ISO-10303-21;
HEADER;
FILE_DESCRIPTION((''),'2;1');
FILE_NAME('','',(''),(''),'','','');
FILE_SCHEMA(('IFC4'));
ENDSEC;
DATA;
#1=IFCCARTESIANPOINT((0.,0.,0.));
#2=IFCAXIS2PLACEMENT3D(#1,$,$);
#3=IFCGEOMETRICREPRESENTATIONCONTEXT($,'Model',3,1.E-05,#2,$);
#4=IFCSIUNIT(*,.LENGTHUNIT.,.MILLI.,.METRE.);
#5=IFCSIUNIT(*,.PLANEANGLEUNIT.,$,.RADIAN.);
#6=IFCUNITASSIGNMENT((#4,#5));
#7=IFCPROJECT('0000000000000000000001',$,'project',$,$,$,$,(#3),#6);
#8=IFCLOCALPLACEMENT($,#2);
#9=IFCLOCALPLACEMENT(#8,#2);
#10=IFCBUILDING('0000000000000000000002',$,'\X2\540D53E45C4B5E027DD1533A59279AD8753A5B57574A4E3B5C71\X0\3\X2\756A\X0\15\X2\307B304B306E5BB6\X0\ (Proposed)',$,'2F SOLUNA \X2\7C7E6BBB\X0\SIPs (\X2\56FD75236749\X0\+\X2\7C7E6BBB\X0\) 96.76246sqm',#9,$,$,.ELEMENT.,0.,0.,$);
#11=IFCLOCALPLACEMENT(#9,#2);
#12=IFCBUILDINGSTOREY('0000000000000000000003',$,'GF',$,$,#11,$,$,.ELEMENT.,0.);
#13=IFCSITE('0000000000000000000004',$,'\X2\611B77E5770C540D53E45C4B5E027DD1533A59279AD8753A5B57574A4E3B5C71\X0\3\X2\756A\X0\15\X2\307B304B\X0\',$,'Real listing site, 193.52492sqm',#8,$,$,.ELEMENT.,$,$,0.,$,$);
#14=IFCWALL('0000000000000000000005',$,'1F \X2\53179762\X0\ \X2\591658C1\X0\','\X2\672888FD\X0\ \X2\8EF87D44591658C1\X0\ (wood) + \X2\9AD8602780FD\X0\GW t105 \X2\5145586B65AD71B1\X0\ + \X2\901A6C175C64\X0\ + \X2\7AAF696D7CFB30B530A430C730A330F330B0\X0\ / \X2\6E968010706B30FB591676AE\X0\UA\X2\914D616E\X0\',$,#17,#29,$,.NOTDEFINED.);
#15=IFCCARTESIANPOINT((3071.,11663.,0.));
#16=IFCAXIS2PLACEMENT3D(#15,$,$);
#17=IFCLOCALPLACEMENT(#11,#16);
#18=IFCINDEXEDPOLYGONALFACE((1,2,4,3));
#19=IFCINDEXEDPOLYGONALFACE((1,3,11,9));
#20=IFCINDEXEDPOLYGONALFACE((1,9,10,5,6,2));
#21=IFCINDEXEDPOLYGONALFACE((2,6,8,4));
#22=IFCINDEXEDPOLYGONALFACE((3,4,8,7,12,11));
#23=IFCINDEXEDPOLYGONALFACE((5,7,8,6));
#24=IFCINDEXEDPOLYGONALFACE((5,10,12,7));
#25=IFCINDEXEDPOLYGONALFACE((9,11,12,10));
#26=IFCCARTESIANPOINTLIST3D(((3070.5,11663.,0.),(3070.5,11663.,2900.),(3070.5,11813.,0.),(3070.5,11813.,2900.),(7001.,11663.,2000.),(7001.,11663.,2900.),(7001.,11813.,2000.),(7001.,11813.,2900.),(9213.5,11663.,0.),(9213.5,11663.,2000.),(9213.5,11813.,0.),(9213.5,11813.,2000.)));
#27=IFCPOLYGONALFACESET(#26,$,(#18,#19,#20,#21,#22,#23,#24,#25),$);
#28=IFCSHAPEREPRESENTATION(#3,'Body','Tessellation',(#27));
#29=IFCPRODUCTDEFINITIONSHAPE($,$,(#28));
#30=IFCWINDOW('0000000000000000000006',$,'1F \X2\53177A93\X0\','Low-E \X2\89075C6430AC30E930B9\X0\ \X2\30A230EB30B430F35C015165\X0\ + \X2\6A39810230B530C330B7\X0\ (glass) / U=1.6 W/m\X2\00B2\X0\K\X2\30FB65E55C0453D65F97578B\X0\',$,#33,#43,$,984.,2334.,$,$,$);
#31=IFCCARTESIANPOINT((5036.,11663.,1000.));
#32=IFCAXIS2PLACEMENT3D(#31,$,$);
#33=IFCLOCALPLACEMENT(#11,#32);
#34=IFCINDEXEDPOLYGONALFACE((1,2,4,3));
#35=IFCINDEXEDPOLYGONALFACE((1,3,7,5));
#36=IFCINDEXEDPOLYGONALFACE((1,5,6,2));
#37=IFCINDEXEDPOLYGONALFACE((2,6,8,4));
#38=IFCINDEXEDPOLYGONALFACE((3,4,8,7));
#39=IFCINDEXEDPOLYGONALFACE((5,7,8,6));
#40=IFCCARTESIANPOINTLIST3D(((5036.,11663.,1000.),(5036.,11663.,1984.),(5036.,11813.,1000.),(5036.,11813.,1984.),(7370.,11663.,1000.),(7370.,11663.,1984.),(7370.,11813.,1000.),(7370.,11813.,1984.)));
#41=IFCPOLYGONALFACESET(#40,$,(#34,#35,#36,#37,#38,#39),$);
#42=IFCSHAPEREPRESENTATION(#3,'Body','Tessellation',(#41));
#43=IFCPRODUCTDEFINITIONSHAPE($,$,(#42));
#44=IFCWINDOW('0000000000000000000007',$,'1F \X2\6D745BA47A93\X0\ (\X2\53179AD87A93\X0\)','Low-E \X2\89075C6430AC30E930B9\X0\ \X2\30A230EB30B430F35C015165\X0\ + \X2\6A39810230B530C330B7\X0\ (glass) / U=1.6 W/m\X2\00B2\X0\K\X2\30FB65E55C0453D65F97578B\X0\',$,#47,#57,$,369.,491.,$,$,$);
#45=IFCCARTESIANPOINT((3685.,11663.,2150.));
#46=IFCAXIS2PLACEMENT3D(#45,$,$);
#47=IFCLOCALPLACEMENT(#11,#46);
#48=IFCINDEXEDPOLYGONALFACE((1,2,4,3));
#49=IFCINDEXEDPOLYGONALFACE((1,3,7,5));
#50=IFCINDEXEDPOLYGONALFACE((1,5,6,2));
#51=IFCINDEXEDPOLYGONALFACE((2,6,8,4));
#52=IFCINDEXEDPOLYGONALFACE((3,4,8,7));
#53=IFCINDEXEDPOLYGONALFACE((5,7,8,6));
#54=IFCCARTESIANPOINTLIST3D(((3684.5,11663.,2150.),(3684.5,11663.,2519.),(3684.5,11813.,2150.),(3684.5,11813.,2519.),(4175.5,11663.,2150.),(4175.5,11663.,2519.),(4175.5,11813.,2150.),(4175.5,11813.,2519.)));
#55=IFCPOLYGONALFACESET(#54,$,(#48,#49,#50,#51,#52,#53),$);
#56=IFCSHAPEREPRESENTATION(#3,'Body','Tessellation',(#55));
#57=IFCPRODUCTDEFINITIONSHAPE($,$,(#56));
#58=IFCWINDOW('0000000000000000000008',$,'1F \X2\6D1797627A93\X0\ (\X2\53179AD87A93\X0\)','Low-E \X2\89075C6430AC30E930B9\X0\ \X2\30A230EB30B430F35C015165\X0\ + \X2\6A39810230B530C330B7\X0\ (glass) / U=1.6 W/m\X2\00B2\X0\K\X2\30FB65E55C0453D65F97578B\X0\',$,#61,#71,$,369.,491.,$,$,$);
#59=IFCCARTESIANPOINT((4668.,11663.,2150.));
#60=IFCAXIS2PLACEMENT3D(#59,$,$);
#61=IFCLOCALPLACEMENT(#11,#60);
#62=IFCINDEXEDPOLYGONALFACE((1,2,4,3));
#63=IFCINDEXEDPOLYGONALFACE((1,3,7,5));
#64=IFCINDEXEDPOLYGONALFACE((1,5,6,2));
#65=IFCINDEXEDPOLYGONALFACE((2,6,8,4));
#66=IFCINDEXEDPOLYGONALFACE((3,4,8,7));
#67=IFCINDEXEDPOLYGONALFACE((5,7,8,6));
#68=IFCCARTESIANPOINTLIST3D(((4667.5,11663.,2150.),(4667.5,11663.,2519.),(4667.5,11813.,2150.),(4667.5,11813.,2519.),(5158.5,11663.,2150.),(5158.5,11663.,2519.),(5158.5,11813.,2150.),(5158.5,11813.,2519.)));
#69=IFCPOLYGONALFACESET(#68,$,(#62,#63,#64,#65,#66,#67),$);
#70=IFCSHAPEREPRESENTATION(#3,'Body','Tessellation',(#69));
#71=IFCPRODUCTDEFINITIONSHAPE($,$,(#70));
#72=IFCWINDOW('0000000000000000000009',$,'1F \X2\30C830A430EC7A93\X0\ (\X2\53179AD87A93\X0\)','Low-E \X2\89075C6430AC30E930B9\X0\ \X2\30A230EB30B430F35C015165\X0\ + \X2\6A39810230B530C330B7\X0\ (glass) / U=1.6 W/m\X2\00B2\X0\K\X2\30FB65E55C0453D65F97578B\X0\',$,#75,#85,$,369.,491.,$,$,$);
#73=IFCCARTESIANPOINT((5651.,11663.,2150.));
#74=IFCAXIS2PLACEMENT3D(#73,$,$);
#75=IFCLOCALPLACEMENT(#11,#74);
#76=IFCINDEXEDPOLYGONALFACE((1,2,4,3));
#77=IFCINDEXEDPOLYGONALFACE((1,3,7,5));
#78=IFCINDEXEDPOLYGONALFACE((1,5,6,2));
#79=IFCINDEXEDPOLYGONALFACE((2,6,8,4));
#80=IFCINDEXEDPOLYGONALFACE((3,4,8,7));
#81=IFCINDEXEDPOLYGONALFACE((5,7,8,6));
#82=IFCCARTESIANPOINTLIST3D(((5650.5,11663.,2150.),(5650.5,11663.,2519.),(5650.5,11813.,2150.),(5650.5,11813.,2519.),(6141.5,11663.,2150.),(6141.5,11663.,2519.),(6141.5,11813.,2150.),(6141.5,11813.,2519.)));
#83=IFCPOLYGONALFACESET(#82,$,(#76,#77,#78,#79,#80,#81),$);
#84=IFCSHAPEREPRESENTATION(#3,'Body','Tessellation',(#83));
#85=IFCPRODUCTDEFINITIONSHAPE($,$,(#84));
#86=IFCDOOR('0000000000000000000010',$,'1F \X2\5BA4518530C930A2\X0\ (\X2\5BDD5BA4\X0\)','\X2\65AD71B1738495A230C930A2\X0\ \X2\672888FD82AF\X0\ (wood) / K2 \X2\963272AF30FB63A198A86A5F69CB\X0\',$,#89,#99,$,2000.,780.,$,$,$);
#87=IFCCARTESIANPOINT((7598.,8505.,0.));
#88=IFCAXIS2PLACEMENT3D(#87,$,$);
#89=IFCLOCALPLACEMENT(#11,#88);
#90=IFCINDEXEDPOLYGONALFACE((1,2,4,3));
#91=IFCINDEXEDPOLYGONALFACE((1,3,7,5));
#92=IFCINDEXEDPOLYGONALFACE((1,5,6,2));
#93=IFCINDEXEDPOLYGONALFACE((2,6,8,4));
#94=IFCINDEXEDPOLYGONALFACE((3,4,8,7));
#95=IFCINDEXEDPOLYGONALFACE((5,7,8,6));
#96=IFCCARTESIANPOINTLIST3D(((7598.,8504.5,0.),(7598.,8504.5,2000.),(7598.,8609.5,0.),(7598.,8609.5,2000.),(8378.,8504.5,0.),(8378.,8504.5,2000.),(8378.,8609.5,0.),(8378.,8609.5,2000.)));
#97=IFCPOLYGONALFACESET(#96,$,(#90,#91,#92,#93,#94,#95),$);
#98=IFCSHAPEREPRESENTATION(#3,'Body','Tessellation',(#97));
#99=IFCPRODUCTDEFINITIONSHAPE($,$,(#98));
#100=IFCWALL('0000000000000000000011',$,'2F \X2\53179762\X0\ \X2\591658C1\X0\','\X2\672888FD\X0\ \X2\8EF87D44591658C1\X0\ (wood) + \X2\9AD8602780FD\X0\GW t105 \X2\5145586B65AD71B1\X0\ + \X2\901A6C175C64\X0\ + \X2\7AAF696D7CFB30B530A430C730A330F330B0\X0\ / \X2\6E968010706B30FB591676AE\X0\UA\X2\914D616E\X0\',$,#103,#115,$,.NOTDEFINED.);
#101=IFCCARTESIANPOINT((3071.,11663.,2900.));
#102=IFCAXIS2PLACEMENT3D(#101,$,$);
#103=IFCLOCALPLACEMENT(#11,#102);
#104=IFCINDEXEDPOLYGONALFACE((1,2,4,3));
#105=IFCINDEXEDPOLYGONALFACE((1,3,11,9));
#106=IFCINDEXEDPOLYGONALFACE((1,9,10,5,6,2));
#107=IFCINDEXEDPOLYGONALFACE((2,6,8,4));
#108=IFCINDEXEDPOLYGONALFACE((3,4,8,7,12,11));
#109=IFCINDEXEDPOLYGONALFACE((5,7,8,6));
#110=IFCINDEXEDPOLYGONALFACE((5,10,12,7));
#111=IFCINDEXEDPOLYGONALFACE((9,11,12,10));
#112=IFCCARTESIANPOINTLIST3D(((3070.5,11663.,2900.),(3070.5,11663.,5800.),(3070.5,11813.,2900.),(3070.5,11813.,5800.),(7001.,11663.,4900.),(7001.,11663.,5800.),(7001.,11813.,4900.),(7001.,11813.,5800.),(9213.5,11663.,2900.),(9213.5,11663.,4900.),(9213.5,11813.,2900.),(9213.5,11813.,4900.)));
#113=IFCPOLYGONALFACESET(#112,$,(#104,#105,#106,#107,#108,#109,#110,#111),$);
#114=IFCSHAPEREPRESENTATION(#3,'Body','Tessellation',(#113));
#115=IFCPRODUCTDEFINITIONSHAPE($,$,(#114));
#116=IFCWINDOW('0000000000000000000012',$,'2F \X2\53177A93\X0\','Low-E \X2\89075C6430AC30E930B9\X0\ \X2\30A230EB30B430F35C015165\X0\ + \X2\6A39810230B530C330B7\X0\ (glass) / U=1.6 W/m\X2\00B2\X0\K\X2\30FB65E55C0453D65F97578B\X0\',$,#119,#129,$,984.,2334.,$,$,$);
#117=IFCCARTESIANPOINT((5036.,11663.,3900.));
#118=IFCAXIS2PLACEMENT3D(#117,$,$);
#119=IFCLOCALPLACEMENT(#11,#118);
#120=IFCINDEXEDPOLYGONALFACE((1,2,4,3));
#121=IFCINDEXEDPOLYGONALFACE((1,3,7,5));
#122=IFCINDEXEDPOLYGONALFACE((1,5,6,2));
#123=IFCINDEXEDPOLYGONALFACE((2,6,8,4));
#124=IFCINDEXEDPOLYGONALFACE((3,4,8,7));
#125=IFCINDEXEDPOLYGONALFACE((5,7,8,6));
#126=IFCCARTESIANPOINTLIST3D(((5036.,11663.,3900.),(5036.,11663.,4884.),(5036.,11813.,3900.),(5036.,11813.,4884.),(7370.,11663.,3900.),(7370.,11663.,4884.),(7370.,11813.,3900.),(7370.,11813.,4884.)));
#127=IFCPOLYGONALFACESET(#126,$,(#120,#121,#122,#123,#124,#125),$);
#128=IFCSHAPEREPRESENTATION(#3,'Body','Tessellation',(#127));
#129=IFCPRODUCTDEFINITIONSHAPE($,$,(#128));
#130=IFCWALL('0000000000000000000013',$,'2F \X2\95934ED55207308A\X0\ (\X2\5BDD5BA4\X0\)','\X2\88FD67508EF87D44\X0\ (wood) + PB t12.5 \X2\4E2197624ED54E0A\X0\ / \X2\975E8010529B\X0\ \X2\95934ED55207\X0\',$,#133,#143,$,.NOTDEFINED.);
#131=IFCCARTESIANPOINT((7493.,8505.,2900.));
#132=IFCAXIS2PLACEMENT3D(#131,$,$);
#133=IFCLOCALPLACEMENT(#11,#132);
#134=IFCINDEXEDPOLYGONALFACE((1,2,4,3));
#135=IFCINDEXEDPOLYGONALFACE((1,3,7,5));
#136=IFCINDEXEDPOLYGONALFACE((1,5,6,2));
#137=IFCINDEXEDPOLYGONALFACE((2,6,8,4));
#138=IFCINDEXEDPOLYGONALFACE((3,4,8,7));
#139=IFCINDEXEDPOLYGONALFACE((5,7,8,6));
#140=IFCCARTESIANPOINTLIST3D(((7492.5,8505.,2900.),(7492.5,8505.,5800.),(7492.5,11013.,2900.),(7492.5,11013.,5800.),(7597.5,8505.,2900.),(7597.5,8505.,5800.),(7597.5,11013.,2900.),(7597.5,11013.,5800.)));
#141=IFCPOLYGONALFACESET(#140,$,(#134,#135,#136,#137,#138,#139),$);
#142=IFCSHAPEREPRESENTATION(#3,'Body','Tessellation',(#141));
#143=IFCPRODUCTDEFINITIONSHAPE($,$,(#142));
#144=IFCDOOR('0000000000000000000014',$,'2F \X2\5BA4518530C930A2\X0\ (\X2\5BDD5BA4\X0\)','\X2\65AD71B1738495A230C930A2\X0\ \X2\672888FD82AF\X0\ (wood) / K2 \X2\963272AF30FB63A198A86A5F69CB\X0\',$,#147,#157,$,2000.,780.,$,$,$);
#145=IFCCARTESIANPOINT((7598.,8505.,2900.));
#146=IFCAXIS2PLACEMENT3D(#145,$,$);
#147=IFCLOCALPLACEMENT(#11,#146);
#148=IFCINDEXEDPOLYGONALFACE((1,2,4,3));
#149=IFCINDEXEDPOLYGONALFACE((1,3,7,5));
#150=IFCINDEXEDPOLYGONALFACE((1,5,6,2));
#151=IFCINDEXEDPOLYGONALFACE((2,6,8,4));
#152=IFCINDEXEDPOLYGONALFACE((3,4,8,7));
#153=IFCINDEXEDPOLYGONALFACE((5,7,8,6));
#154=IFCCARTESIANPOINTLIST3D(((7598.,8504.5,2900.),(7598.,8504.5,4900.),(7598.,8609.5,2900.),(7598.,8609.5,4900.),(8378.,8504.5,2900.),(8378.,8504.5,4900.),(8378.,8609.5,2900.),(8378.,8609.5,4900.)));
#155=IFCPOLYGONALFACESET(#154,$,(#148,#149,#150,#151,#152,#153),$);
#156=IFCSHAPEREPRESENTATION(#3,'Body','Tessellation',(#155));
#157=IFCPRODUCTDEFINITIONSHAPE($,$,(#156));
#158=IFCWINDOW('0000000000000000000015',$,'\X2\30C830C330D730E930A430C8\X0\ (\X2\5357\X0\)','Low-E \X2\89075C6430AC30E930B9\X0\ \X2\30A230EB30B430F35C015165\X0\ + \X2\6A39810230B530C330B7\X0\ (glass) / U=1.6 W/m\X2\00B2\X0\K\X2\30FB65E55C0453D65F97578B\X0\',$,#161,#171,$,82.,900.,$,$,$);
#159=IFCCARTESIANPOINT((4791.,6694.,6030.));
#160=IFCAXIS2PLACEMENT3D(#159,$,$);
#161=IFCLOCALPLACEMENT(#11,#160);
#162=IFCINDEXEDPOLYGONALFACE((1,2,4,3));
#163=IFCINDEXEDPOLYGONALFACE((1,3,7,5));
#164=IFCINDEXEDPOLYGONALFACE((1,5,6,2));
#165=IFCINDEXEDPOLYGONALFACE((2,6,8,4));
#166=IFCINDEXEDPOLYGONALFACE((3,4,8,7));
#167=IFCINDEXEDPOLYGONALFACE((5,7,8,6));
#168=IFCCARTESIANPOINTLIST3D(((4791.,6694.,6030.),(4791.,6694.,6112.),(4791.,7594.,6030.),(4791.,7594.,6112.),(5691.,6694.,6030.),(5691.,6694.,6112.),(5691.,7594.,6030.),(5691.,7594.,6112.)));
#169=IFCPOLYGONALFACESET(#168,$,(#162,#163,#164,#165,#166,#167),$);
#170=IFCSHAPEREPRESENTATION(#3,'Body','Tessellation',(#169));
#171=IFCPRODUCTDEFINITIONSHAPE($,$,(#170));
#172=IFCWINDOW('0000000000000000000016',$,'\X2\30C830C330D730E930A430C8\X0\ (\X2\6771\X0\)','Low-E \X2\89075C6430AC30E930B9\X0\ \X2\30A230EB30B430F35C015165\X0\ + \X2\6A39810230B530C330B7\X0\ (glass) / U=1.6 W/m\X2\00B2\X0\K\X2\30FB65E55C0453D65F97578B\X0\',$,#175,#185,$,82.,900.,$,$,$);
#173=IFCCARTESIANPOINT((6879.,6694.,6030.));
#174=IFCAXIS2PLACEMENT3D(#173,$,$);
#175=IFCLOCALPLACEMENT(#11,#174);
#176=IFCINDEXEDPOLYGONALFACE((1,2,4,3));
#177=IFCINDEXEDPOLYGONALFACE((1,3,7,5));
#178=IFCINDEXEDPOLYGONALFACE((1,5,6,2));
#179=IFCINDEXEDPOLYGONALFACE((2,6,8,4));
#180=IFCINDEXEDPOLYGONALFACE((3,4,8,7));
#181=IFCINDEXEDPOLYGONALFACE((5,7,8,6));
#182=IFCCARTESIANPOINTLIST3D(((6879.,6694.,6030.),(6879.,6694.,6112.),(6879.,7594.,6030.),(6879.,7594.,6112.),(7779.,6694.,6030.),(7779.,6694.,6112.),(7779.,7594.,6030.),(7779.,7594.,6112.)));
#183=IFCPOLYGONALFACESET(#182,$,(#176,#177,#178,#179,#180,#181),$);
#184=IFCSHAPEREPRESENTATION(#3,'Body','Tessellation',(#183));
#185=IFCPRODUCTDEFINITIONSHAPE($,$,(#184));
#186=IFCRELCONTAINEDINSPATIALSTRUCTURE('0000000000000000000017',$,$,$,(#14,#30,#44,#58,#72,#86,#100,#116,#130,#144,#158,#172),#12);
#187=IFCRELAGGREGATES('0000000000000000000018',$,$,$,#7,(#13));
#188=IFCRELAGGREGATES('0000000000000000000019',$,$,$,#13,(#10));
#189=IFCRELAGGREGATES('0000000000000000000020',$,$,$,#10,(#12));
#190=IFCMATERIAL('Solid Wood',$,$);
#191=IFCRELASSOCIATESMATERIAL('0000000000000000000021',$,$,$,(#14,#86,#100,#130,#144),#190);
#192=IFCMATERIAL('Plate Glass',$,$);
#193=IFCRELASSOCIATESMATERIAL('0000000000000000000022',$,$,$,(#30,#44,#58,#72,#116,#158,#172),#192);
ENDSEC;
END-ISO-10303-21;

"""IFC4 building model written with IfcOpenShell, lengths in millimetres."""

from ifc_helpers import new_model, si_unit, frame, frame_2d, origin, place, context, project, spatial, rectangle, extrude, material, element, fill, save


model = new_model("IFC4")

# Units and contexts
model_context = context("Model", 3, precision=1e-05, world=origin())
ifc_project = project(units=[si_unit("LENGTHUNIT", "METRE", prefix="MILLI"), si_unit("PLANEANGLEUNIT", "RADIAN")], contexts=[model_context])

# Site, building, storey
site_placement = place(None, origin())
site = spatial("IfcSite", under=ifc_project, at=site_placement, Name="愛知県名古屋市緑区大高町字坊主山3番15ほか", ObjectType="Real listing site, 193.52492sqm", CompositionType="ELEMENT", RefElevation=0.0)
building_placement = place(site_placement, origin())
building = spatial("IfcBuilding", under=site, at=building_placement, Name="名古屋市緑区大高町字坊主山3番15ほかの家 (Proposed)", ObjectType="2F SOLUNA 籾殻SIPs (国産杉+籾殻) 96.76246sqm", CompositionType="ELEMENT", ElevationOfRefHeight=0.0, ElevationOfTerrain=0.0)
storey_placement = place(building_placement, origin())
storey = spatial("IfcBuildingStorey", under=building, at=storey_placement, Name="GF", CompositionType="ELEMENT", Elevation=0.0)

# Wall, openings, windows
ifc_material_1 = material(Name="Solid Wood")
wall_1_placement = place(storey_placement, frame((3071.0, 11663.0, 0.0)))
wall_1 = element("IfcWall", 1, at=wall_1_placement, inside=storey, material=ifc_material_1, Name="1F 北面 外壁", Description="木製 軸組外壁 (wood) + 高性能GW t105 充填断熱 + 通気層 + 窯業系サイディング / 準耐火・外皮UA配慮", PredefinedType="NOTDEFINED", context=model_context, shape_type="SweptSolid", body=[
    extrude(rectangle(XDim=6143.0, YDim=150.0, at=frame_2d((3071.0, 75.0))), frame((3071.0, 11663.0, 0.0)), (0.0, 0.0, 1.0), 2900.0),
])
opening_1_placement = place(storey_placement, frame((5036.0, 11663.0, 1000.0)))
opening_1 = element("IfcOpeningElement", 2, at=opening_1_placement, cuts=wall_1, PredefinedType="NOTDEFINED", context=model_context, shape_type="SweptSolid", body=[
    extrude(rectangle(XDim=2334.0, YDim=150.0, at=frame_2d((1167.0, 75.0))), frame((5036.0, 11663.0, 1000.0)), (0.0, 0.0, 1.0), 984.0),
])
opening_2_placement = place(storey_placement, frame((3685.0, 11663.0, 2150.0)))
opening_2 = element("IfcOpeningElement", 3, at=opening_2_placement, cuts=wall_1, PredefinedType="NOTDEFINED", context=model_context, shape_type="SweptSolid", body=[
    extrude(rectangle(XDim=491.0, YDim=150.0, at=frame_2d((245.0, 75.0))), frame((3685.0, 11663.0, 2150.0)), (0.0, 0.0, 1.0), 369.0),
])
opening_3_placement = place(storey_placement, frame((4668.0, 11663.0, 2150.0)))
opening_3 = element("IfcOpeningElement", 4, at=opening_3_placement, cuts=wall_1, PredefinedType="NOTDEFINED", context=model_context, shape_type="SweptSolid", body=[
    extrude(rectangle(XDim=491.0, YDim=150.0, at=frame_2d((245.0, 75.0))), frame((4668.0, 11663.0, 2150.0)), (0.0, 0.0, 1.0), 369.0),
])
opening_4_placement = place(storey_placement, frame((5651.0, 11663.0, 2150.0)))
opening_4 = element("IfcOpeningElement", 5, at=opening_4_placement, cuts=wall_1, PredefinedType="NOTDEFINED", context=model_context, shape_type="SweptSolid", body=[
    extrude(rectangle(XDim=491.0, YDim=150.0, at=frame_2d((245.0, 75.0))), frame((5651.0, 11663.0, 2150.0)), (0.0, 0.0, 1.0), 369.0),
])
ifc_material_2 = material(Name="Plate Glass")
window_1_placement = place(storey_placement, frame((5036.0, 11663.0, 1000.0)))
window_1 = element("IfcWindow", 6, at=window_1_placement, inside=storey, material=ifc_material_2, Name="1F 北窓", Description="Low-E 複層ガラス アルゴン封入 + 樹脂サッシ (glass) / U=1.6 W/m²K・日射取得型", OverallHeight=984.0, OverallWidth=2334.0, context=model_context, shape_type="SweptSolid", body=[
    extrude(rectangle(XDim=2334.0, YDim=150.0, at=frame_2d((1167.0, 75.0))), frame((5036.0, 11663.0, 1000.0)), (0.0, 0.0, 1.0), 984.0),
])
fill(opening_1, window_1)
window_2_placement = place(storey_placement, frame((3685.0, 11663.0, 2150.0)))
window_2 = element("IfcWindow", 7, at=window_2_placement, inside=storey, material=ifc_material_2, Name="1F 浴室窓 (北高窓)", Description="Low-E 複層ガラス アルゴン封入 + 樹脂サッシ (glass) / U=1.6 W/m²K・日射取得型", OverallHeight=369.0, OverallWidth=491.0, context=model_context, shape_type="SweptSolid", body=[
    extrude(rectangle(XDim=491.0, YDim=150.0, at=frame_2d((245.0, 75.0))), frame((3685.0, 11663.0, 2150.0)), (0.0, 0.0, 1.0), 369.0),
])
fill(opening_2, window_2)
window_3_placement = place(storey_placement, frame((4668.0, 11663.0, 2150.0)))
window_3 = element("IfcWindow", 8, at=window_3_placement, inside=storey, material=ifc_material_2, Name="1F 洗面窓 (北高窓)", Description="Low-E 複層ガラス アルゴン封入 + 樹脂サッシ (glass) / U=1.6 W/m²K・日射取得型", OverallHeight=369.0, OverallWidth=491.0, context=model_context, shape_type="SweptSolid", body=[
    extrude(rectangle(XDim=491.0, YDim=150.0, at=frame_2d((245.0, 75.0))), frame((4668.0, 11663.0, 2150.0)), (0.0, 0.0, 1.0), 369.0),
])
fill(opening_3, window_3)
window_4_placement = place(storey_placement, frame((5651.0, 11663.0, 2150.0)))
window_4 = element("IfcWindow", 9, at=window_4_placement, inside=storey, material=ifc_material_2, Name="1F トイレ窓 (北高窓)", Description="Low-E 複層ガラス アルゴン封入 + 樹脂サッシ (glass) / U=1.6 W/m²K・日射取得型", OverallHeight=369.0, OverallWidth=491.0, context=model_context, shape_type="SweptSolid", body=[
    extrude(rectangle(XDim=491.0, YDim=150.0, at=frame_2d((245.0, 75.0))), frame((5651.0, 11663.0, 2150.0)), (0.0, 0.0, 1.0), 369.0),
])
fill(opening_4, window_4)

# Door
door_1_placement = place(storey_placement, frame((7598.0, 8505.0, 0.0)))
element("IfcDoor", 10, at=door_1_placement, inside=storey, material=ifc_material_1, Name="1F 室内ドア (寝室)", Description="断熱玄関ドア 木製芯 (wood) / K2 防犯・採風機構", OverallHeight=2000.0, OverallWidth=780.0, context=model_context, shape_type="SweptSolid", body=[
    extrude(rectangle(XDim=780.0, YDim=105.0, at=frame_2d((390.0, 52.0))), frame((7598.0, 8505.0, 0.0)), (0.0, 0.0, 1.0), 2000.0),
])

# Wall, opening, window
wall_2_placement = place(storey_placement, frame((3071.0, 11663.0, 2900.0)))
wall_2 = element("IfcWall", 11, at=wall_2_placement, inside=storey, material=ifc_material_1, Name="2F 北面 外壁", Description="木製 軸組外壁 (wood) + 高性能GW t105 充填断熱 + 通気層 + 窯業系サイディング / 準耐火・外皮UA配慮", PredefinedType="NOTDEFINED", context=model_context, shape_type="SweptSolid", body=[
    extrude(rectangle(XDim=6143.0, YDim=150.0, at=frame_2d((3071.0, 75.0))), frame((3071.0, 11663.0, 2900.0)), (0.0, 0.0, 1.0), 2900.0),
])
opening_5_placement = place(storey_placement, frame((5036.0, 11663.0, 3900.0)))
opening_5 = element("IfcOpeningElement", 12, at=opening_5_placement, cuts=wall_2, PredefinedType="NOTDEFINED", context=model_context, shape_type="SweptSolid", body=[
    extrude(rectangle(XDim=2334.0, YDim=150.0, at=frame_2d((1167.0, 75.0))), frame((5036.0, 11663.0, 3900.0)), (0.0, 0.0, 1.0), 984.0),
])
window_5_placement = place(storey_placement, frame((5036.0, 11663.0, 3900.0)))
window_5 = element("IfcWindow", 13, at=window_5_placement, inside=storey, material=ifc_material_2, Name="2F 北窓", Description="Low-E 複層ガラス アルゴン封入 + 樹脂サッシ (glass) / U=1.6 W/m²K・日射取得型", OverallHeight=984.0, OverallWidth=2334.0, context=model_context, shape_type="SweptSolid", body=[
    extrude(rectangle(XDim=2334.0, YDim=150.0, at=frame_2d((1167.0, 75.0))), frame((5036.0, 11663.0, 3900.0)), (0.0, 0.0, 1.0), 984.0),
])
fill(opening_5, window_5)

# Wall
wall_3_placement = place(storey_placement, frame((7493.0, 8505.0, 2900.0)))
element("IfcWall", 14, at=wall_3_placement, inside=storey, material=ifc_material_1, Name="2F 間仕切り (寝室)", Description="製材軸組 (wood) + PB t12.5 両面仕上 / 非耐力 間仕切", PredefinedType="NOTDEFINED", context=model_context, shape_type="SweptSolid", body=[
    extrude(rectangle(XDim=105.0, YDim=2508.0, at=frame_2d((52.0, 1254.0))), frame((7493.0, 8505.0, 2900.0)), (0.0, 0.0, 1.0), 2900.0),
])

# Door
door_2_placement = place(storey_placement, frame((7598.0, 8505.0, 2900.0)))
element("IfcDoor", 15, at=door_2_placement, inside=storey, material=ifc_material_1, Name="2F 室内ドア (寝室)", Description="断熱玄関ドア 木製芯 (wood) / K2 防犯・採風機構", OverallHeight=2000.0, OverallWidth=780.0, context=model_context, shape_type="SweptSolid", body=[
    extrude(rectangle(XDim=780.0, YDim=105.0, at=frame_2d((390.0, 52.0))), frame((7598.0, 8505.0, 2900.0)), (0.0, 0.0, 1.0), 2000.0),
])

# Windows
window_6_placement = place(storey_placement, frame((4791.0, 6694.0, 6030.0)))
element("IfcWindow", 16, at=window_6_placement, inside=storey, material=ifc_material_2, Name="トップライト (南)", Description="Low-E 複層ガラス アルゴン封入 + 樹脂サッシ (glass) / U=1.6 W/m²K・日射取得型", OverallHeight=82.0, OverallWidth=900.0, context=model_context, shape_type="SweptSolid", body=[
    extrude(rectangle(XDim=900.0, YDim=900.0, at=frame_2d((450.0, 450.0))), frame((4791.0, 6694.0, 6030.0)), (0.0, 0.0, 1.0), 82.0),
])
window_7_placement = place(storey_placement, frame((6879.0, 6694.0, 6030.0)))
element("IfcWindow", 17, at=window_7_placement, inside=storey, material=ifc_material_2, Name="トップライト (東)", Description="Low-E 複層ガラス アルゴン封入 + 樹脂サッシ (glass) / U=1.6 W/m²K・日射取得型", OverallHeight=82.0, OverallWidth=900.0, context=model_context, shape_type="SweptSolid", body=[
    extrude(rectangle(XDim=900.0, YDim=900.0, at=frame_2d((450.0, 450.0))), frame((6879.0, 6694.0, 6030.0)), (0.0, 0.0, 1.0), 82.0),
])

save(model, "model.ifc")
